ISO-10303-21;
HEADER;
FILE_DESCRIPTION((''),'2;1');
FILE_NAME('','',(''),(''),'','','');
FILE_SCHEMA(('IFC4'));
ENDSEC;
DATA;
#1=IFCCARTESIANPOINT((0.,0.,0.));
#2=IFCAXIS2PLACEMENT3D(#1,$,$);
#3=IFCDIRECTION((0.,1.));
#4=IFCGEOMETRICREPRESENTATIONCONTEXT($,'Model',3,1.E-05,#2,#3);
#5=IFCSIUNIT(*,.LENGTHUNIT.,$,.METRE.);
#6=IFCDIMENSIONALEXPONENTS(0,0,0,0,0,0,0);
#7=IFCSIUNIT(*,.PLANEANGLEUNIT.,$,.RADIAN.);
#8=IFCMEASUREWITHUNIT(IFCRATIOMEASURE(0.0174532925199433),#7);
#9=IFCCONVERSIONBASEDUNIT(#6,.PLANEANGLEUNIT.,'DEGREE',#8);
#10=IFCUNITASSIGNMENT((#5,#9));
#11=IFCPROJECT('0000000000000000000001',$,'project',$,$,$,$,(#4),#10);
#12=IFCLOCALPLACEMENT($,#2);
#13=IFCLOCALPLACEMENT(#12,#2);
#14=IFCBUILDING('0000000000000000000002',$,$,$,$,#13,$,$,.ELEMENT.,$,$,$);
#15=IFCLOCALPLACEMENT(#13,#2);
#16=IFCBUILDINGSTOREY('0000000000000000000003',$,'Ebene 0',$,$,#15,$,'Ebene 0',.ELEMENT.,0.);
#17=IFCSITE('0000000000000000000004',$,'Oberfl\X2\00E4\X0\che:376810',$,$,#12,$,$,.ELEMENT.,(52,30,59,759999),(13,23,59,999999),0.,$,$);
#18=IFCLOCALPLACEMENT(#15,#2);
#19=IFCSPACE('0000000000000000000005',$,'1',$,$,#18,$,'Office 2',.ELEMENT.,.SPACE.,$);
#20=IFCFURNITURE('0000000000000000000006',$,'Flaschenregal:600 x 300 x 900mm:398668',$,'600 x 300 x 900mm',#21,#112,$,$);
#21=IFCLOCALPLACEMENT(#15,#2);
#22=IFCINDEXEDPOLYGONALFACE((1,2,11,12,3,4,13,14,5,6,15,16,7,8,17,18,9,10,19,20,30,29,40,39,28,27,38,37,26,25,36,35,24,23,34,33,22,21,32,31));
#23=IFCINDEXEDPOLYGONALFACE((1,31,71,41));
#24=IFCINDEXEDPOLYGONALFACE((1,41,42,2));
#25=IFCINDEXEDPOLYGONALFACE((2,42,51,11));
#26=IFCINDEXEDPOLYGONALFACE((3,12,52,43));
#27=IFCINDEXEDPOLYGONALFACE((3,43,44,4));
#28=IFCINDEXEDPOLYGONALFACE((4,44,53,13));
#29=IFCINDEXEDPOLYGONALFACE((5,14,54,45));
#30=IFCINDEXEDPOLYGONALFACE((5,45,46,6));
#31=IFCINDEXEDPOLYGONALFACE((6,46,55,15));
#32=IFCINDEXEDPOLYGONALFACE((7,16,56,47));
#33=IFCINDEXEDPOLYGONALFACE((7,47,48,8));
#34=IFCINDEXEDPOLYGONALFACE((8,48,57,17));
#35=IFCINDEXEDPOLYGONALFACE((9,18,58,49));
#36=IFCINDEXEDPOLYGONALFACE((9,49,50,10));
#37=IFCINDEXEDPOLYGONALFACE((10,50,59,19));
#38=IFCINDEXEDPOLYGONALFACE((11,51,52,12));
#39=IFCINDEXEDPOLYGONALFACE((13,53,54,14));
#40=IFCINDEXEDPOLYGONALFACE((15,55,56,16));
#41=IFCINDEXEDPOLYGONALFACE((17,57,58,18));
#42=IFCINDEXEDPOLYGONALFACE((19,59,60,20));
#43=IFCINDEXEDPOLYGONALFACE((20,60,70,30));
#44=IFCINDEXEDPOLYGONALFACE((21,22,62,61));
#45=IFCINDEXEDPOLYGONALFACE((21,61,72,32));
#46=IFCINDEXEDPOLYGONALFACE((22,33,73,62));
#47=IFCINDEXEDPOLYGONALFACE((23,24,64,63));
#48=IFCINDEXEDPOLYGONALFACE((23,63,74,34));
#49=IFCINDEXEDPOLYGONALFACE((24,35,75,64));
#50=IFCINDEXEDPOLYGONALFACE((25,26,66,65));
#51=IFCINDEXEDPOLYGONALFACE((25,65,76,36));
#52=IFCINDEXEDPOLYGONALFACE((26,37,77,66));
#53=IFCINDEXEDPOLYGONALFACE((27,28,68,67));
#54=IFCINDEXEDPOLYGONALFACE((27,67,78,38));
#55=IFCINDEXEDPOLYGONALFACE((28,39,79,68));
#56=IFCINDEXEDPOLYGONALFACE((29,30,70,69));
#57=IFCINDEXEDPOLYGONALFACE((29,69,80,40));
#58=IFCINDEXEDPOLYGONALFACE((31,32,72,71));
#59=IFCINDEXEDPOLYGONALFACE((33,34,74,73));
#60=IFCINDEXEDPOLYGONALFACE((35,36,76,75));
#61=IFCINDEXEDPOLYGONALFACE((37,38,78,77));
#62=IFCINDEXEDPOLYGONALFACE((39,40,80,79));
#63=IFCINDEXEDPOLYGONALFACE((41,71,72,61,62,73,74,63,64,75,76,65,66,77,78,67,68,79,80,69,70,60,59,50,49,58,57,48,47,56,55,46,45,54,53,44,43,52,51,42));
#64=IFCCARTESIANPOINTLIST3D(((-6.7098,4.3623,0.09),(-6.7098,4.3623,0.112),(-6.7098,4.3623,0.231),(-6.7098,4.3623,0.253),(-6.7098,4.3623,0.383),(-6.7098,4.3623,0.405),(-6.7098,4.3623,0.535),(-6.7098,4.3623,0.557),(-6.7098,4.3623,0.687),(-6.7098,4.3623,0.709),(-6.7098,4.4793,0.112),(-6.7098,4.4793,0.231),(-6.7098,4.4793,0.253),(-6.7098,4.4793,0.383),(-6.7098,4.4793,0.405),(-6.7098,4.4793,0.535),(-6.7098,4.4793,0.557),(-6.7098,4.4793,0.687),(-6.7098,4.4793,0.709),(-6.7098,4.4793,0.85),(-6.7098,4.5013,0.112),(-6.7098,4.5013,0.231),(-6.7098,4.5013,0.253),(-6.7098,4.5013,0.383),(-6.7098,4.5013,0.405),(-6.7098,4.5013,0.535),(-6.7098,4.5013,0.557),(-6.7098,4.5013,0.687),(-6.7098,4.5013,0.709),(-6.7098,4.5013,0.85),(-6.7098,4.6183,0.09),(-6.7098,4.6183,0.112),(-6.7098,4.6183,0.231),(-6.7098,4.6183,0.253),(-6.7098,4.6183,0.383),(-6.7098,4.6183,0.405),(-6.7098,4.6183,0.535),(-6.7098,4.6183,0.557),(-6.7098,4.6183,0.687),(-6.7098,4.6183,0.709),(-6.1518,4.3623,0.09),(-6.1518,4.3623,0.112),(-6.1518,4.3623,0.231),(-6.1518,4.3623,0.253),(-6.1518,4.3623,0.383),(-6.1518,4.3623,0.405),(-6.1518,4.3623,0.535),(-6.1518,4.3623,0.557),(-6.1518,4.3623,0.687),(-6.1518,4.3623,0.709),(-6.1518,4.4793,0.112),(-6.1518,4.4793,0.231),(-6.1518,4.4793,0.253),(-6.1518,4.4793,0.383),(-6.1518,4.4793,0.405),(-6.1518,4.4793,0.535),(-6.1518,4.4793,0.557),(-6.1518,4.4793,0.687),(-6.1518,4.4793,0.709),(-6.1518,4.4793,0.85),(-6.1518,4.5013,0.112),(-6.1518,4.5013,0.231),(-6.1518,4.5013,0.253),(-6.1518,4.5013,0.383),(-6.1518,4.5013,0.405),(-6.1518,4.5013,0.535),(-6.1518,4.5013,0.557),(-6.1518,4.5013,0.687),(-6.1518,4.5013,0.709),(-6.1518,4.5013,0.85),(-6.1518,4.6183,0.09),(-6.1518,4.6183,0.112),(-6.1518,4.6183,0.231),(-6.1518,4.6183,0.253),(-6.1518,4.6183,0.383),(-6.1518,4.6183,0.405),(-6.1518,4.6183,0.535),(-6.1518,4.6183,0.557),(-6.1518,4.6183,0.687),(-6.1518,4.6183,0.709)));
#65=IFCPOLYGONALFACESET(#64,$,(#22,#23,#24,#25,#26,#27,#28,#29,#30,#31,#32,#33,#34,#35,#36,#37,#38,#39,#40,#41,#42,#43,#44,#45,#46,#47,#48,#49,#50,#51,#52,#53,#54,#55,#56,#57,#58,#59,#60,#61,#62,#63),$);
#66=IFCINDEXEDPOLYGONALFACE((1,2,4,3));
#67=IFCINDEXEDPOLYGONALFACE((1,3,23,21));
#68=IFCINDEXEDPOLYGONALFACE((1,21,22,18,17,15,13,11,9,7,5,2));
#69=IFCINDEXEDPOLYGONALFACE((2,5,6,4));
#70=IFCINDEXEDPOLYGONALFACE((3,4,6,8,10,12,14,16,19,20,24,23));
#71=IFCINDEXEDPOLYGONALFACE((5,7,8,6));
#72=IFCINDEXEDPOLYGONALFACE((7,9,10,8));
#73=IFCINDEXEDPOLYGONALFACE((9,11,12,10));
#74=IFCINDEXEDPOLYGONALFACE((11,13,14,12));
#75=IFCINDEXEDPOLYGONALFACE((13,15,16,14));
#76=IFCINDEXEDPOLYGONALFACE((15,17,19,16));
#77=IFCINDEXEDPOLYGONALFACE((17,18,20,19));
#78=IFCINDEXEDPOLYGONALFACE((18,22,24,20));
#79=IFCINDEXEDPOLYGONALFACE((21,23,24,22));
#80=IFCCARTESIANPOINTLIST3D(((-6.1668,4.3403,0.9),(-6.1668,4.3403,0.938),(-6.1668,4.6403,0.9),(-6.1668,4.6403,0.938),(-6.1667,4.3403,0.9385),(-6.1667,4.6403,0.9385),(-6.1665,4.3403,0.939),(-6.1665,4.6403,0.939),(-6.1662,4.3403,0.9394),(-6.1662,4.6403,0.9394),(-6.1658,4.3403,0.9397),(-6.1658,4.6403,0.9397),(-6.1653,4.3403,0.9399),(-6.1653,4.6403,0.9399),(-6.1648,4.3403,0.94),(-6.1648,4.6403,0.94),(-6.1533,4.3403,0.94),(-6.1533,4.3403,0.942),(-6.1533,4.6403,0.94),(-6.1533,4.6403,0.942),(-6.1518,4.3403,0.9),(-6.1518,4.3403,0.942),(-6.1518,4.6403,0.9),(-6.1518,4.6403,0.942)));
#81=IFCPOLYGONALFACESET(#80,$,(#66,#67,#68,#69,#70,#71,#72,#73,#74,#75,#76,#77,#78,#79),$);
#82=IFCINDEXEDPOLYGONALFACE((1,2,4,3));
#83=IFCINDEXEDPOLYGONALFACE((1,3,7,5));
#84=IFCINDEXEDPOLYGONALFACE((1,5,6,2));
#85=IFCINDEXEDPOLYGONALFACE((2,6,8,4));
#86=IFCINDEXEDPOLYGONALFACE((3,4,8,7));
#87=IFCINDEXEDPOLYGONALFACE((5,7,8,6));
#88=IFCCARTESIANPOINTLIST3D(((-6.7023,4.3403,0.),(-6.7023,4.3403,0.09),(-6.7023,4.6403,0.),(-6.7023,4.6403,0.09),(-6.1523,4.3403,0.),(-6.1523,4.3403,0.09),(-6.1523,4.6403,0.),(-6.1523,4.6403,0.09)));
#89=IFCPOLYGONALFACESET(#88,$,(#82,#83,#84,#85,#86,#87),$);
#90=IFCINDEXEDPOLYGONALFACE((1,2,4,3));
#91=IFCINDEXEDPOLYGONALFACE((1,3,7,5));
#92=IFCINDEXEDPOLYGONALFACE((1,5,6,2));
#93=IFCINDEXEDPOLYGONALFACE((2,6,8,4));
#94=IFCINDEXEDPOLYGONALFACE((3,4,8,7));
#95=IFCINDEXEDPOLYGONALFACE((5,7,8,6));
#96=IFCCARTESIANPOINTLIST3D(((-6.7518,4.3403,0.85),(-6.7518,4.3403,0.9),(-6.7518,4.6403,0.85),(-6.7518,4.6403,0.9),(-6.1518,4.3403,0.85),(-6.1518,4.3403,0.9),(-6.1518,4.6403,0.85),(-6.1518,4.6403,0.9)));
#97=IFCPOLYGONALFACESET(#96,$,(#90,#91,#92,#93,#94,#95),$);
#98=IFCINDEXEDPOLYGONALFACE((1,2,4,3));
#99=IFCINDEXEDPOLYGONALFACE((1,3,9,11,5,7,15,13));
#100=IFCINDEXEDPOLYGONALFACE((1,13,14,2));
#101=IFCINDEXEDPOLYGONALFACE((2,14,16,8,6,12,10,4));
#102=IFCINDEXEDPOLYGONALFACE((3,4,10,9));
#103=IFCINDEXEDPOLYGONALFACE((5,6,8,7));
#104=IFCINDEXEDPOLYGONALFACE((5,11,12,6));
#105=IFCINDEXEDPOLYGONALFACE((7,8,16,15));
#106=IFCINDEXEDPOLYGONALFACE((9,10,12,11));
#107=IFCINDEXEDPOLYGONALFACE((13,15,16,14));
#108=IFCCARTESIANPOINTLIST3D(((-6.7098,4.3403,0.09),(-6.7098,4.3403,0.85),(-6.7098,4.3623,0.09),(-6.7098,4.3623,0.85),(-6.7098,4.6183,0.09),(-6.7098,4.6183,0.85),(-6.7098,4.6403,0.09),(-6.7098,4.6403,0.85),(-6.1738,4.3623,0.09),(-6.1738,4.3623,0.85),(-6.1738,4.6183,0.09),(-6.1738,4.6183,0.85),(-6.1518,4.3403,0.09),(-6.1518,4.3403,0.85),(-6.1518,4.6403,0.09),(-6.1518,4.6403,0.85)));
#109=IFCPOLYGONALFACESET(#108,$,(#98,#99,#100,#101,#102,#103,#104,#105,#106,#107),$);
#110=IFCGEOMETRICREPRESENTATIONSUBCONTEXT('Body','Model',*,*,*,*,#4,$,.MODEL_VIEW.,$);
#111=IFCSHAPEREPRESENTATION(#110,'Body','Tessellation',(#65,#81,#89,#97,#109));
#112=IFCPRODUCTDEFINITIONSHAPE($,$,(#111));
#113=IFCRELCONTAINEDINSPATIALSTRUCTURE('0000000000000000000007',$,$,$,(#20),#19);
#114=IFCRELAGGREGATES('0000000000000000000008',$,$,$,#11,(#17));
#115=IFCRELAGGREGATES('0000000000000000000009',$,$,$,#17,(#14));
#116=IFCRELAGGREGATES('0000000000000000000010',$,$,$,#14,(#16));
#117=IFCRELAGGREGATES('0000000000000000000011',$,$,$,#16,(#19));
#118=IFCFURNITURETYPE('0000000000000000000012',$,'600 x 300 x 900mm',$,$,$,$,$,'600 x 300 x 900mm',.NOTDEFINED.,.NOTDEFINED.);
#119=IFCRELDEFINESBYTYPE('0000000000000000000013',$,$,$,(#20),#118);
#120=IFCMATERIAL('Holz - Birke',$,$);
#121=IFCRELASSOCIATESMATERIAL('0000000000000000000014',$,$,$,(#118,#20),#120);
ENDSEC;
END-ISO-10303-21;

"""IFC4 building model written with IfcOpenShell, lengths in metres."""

from ifc_helpers import new_model, entity, si_unit, converted_unit, direction, frame, frame_2d, origin, origin_2d_with_axis, place, context, subcontext, project, spatial, polyline, circle_curve, parameter, trimmed, segment, composite_curve, rectangle, outline, extrude, source, transform, mapped, material, type_object, type_shapes, element, save


model = new_model("IFC4")

# Units and contexts
model_context = context("Model", 3, precision=1e-05, world=origin(), true_north=direction((0.0, 1.0)))
body_context = subcontext(model_context, "Body", "Model", "MODEL_VIEW")
ifc_project = project(units=[si_unit("LENGTHUNIT", "METRE"), converted_unit("PLANEANGLEUNIT", "DEGREE", entity("IfcRatioMeasure", 0.0174532925199433), si_unit("PLANEANGLEUNIT", "RADIAN"), dimensions=[0, 0, 0, 0, 0, 0, 0])], contexts=[model_context])

# Site, building, storey
site_placement = place(None, origin())
site = spatial("IfcSite", under=ifc_project, at=site_placement, Name="Oberfläche:376810", CompositionType="ELEMENT", RefLatitude=(52, 30, 59, 759999), RefLongitude=(13, 23, 59, 999999), RefElevation=0.0)
building_placement = place(site_placement, origin())
building = spatial("IfcBuilding", under=site, at=building_placement, CompositionType="ELEMENT")
storey_placement = place(building_placement, origin())
storey = spatial("IfcBuildingStorey", under=building, at=storey_placement, Name="Ebene 0", LongName="Ebene 0", CompositionType="ELEMENT", Elevation=0.0)

# Shared definitions
space_placement = place(storey_placement, origin())
space = spatial("IfcSpace", under=storey, at=space_placement, Name="1", LongName="Office 2", CompositionType="ELEMENT", PredefinedType="SPACE")

# Furniture
ifc_material_1 = material(Name="Holz - Birke")
furniture_type_1 = type_object("IfcFurnitureType", Name="600 x 300 x 900mm", ElementType="600 x 300 x 900mm", AssemblyPlace="NOTDEFINED", PredefinedType="NOTDEFINED", material=ifc_material_1)
shared_shape_1 = source(origin(), body_context, "Body", "SweptSolid", [
    extrude(outline(polyline([(-0.3442, -0.128), (-0.3222, -0.128), (-0.3222, -0.011), (-0.2032, -0.011), (-0.2032, -0.128), (-0.1812, -0.128), (-0.1812, -0.011), (-0.0512, -0.011), (-0.0512, -0.128), (-0.0292, -0.128), (-0.0292, -0.011), (0.1008, -0.011), (0.1008, -0.128), (0.1228, -0.128), (0.1228, -0.011), (0.2528, -0.011), (0.2528, -0.128), (0.2748, -0.128), (0.2748, -0.011), (0.4158, -0.011), (0.4158, 0.011), (0.2748, 0.011), (0.2748, 0.128), (0.2528, 0.128), (0.2528, 0.011), (0.1228, 0.011), (0.1228, 0.128), (0.1008, 0.128), (0.1008, 0.011), (-0.0292, 0.011), (-0.0292, 0.128), (-0.0512, 0.128), (-0.0512, 0.011), (-0.1812, 0.011), (-0.1812, 0.128), (-0.2032, 0.128), (-0.2032, 0.011), (-0.3222, 0.011), (-0.3222, 0.128), (-0.3442, 0.128), (-0.3442, -0.128)])), frame((0.0447, -0.558, 0.4342), z_axis=(0.0, 1.0, 0.0), x_axis=(0.0, 0.0, 1.0)), (0.0, 0.0, 1.0), 0.558),
    extrude(outline(composite_curve([segment(polyline([(-0.0066, -0.0131), (-0.0051, -0.0131)]), True, "CONTINUOUS"), segment(polyline([(-0.0051, -0.0131), (-0.0051, -0.0111)]), True, "CONTINUOUS"), segment(polyline([(-0.0051, -0.0111), (0.0064, -0.0111)]), True, "CONTINUOUS"), segment(trimmed(circle_curve(frame_2d((0.0064, -0.0091), x_axis=(1.0, 0.0)), 0.002), [parameter(270.0)], [parameter(0.0)], True, "PARAMETER"), True, "CONTINUOUS"), segment(polyline([(0.0084, -0.0091), (0.0084, 0.0289)]), True, "CONTINUOUS"), segment(polyline([(0.0084, 0.0289), (-0.0066, 0.0289)]), True, "CONTINUOUS"), segment(polyline([(-0.0066, 0.0289), (-0.0066, -0.0131)]), True, "CONTINUOUS")], self_intersect=False)), frame((-0.1053, -0.0066, 0.9289), z_axis=(1.0, 0.0, 0.0), x_axis=(0.0, -1.0, 0.0)), (0.0, 0.0, 1.0), 0.3),
    extrude(rectangle(XDim=0.3, YDim=0.55, at=origin_2d_with_axis()), frame((0.0447, -0.2755, 0.0), z_axis=(0.0, 0.0, 1.0), x_axis=(-1.0, 0.0, 0.0)), (0.0, 0.0, 1.0), 0.09),
    extrude(rectangle(XDim=0.3, YDim=0.6, at=frame_2d((0.0, 0.0), x_axis=(1.0, 0.0))), frame((0.0447, -0.3, 0.85), z_axis=(0.0, 0.0, 1.0), x_axis=(-1.0, 0.0, 0.0)), (0.0, 0.0, 1.0), 0.05),
    extrude(outline(polyline([(-0.15, -0.2845), (0.15, -0.2845), (0.15, 0.2735), (0.128, 0.2735), (0.128, -0.2625), (-0.128, -0.2625), (-0.128, 0.2735), (-0.15, 0.2735), (-0.15, -0.2845)])), frame((0.0447, -0.2845, 0.09), z_axis=(0.0, 0.0, 1.0), x_axis=(-1.0, 0.0, 0.0)), (0.0, 0.0, 1.0), 0.76),
])
type_shapes(furniture_type_1, [shared_shape_1])
furniture_1_placement = place(space_placement, frame((-6.1518, 4.535, 0.0), z_axis=(0.0, 0.0, 1.0), x_axis=(0.0, -1.0, 0.0)))
element("IfcFurniture", 1, at=furniture_1_placement, inside=space, type_object=furniture_type_1, material=ifc_material_1, Name="Flaschenregal:600 x 300 x 900mm:398668", ObjectType="600 x 300 x 900mm", context=body_context, shape_type="MappedRepresentation", body=[
    mapped(shared_shape_1, transform((0.0, 0.0, 0.0), scale=1.0)),
])

save(model, "model.ifc")
